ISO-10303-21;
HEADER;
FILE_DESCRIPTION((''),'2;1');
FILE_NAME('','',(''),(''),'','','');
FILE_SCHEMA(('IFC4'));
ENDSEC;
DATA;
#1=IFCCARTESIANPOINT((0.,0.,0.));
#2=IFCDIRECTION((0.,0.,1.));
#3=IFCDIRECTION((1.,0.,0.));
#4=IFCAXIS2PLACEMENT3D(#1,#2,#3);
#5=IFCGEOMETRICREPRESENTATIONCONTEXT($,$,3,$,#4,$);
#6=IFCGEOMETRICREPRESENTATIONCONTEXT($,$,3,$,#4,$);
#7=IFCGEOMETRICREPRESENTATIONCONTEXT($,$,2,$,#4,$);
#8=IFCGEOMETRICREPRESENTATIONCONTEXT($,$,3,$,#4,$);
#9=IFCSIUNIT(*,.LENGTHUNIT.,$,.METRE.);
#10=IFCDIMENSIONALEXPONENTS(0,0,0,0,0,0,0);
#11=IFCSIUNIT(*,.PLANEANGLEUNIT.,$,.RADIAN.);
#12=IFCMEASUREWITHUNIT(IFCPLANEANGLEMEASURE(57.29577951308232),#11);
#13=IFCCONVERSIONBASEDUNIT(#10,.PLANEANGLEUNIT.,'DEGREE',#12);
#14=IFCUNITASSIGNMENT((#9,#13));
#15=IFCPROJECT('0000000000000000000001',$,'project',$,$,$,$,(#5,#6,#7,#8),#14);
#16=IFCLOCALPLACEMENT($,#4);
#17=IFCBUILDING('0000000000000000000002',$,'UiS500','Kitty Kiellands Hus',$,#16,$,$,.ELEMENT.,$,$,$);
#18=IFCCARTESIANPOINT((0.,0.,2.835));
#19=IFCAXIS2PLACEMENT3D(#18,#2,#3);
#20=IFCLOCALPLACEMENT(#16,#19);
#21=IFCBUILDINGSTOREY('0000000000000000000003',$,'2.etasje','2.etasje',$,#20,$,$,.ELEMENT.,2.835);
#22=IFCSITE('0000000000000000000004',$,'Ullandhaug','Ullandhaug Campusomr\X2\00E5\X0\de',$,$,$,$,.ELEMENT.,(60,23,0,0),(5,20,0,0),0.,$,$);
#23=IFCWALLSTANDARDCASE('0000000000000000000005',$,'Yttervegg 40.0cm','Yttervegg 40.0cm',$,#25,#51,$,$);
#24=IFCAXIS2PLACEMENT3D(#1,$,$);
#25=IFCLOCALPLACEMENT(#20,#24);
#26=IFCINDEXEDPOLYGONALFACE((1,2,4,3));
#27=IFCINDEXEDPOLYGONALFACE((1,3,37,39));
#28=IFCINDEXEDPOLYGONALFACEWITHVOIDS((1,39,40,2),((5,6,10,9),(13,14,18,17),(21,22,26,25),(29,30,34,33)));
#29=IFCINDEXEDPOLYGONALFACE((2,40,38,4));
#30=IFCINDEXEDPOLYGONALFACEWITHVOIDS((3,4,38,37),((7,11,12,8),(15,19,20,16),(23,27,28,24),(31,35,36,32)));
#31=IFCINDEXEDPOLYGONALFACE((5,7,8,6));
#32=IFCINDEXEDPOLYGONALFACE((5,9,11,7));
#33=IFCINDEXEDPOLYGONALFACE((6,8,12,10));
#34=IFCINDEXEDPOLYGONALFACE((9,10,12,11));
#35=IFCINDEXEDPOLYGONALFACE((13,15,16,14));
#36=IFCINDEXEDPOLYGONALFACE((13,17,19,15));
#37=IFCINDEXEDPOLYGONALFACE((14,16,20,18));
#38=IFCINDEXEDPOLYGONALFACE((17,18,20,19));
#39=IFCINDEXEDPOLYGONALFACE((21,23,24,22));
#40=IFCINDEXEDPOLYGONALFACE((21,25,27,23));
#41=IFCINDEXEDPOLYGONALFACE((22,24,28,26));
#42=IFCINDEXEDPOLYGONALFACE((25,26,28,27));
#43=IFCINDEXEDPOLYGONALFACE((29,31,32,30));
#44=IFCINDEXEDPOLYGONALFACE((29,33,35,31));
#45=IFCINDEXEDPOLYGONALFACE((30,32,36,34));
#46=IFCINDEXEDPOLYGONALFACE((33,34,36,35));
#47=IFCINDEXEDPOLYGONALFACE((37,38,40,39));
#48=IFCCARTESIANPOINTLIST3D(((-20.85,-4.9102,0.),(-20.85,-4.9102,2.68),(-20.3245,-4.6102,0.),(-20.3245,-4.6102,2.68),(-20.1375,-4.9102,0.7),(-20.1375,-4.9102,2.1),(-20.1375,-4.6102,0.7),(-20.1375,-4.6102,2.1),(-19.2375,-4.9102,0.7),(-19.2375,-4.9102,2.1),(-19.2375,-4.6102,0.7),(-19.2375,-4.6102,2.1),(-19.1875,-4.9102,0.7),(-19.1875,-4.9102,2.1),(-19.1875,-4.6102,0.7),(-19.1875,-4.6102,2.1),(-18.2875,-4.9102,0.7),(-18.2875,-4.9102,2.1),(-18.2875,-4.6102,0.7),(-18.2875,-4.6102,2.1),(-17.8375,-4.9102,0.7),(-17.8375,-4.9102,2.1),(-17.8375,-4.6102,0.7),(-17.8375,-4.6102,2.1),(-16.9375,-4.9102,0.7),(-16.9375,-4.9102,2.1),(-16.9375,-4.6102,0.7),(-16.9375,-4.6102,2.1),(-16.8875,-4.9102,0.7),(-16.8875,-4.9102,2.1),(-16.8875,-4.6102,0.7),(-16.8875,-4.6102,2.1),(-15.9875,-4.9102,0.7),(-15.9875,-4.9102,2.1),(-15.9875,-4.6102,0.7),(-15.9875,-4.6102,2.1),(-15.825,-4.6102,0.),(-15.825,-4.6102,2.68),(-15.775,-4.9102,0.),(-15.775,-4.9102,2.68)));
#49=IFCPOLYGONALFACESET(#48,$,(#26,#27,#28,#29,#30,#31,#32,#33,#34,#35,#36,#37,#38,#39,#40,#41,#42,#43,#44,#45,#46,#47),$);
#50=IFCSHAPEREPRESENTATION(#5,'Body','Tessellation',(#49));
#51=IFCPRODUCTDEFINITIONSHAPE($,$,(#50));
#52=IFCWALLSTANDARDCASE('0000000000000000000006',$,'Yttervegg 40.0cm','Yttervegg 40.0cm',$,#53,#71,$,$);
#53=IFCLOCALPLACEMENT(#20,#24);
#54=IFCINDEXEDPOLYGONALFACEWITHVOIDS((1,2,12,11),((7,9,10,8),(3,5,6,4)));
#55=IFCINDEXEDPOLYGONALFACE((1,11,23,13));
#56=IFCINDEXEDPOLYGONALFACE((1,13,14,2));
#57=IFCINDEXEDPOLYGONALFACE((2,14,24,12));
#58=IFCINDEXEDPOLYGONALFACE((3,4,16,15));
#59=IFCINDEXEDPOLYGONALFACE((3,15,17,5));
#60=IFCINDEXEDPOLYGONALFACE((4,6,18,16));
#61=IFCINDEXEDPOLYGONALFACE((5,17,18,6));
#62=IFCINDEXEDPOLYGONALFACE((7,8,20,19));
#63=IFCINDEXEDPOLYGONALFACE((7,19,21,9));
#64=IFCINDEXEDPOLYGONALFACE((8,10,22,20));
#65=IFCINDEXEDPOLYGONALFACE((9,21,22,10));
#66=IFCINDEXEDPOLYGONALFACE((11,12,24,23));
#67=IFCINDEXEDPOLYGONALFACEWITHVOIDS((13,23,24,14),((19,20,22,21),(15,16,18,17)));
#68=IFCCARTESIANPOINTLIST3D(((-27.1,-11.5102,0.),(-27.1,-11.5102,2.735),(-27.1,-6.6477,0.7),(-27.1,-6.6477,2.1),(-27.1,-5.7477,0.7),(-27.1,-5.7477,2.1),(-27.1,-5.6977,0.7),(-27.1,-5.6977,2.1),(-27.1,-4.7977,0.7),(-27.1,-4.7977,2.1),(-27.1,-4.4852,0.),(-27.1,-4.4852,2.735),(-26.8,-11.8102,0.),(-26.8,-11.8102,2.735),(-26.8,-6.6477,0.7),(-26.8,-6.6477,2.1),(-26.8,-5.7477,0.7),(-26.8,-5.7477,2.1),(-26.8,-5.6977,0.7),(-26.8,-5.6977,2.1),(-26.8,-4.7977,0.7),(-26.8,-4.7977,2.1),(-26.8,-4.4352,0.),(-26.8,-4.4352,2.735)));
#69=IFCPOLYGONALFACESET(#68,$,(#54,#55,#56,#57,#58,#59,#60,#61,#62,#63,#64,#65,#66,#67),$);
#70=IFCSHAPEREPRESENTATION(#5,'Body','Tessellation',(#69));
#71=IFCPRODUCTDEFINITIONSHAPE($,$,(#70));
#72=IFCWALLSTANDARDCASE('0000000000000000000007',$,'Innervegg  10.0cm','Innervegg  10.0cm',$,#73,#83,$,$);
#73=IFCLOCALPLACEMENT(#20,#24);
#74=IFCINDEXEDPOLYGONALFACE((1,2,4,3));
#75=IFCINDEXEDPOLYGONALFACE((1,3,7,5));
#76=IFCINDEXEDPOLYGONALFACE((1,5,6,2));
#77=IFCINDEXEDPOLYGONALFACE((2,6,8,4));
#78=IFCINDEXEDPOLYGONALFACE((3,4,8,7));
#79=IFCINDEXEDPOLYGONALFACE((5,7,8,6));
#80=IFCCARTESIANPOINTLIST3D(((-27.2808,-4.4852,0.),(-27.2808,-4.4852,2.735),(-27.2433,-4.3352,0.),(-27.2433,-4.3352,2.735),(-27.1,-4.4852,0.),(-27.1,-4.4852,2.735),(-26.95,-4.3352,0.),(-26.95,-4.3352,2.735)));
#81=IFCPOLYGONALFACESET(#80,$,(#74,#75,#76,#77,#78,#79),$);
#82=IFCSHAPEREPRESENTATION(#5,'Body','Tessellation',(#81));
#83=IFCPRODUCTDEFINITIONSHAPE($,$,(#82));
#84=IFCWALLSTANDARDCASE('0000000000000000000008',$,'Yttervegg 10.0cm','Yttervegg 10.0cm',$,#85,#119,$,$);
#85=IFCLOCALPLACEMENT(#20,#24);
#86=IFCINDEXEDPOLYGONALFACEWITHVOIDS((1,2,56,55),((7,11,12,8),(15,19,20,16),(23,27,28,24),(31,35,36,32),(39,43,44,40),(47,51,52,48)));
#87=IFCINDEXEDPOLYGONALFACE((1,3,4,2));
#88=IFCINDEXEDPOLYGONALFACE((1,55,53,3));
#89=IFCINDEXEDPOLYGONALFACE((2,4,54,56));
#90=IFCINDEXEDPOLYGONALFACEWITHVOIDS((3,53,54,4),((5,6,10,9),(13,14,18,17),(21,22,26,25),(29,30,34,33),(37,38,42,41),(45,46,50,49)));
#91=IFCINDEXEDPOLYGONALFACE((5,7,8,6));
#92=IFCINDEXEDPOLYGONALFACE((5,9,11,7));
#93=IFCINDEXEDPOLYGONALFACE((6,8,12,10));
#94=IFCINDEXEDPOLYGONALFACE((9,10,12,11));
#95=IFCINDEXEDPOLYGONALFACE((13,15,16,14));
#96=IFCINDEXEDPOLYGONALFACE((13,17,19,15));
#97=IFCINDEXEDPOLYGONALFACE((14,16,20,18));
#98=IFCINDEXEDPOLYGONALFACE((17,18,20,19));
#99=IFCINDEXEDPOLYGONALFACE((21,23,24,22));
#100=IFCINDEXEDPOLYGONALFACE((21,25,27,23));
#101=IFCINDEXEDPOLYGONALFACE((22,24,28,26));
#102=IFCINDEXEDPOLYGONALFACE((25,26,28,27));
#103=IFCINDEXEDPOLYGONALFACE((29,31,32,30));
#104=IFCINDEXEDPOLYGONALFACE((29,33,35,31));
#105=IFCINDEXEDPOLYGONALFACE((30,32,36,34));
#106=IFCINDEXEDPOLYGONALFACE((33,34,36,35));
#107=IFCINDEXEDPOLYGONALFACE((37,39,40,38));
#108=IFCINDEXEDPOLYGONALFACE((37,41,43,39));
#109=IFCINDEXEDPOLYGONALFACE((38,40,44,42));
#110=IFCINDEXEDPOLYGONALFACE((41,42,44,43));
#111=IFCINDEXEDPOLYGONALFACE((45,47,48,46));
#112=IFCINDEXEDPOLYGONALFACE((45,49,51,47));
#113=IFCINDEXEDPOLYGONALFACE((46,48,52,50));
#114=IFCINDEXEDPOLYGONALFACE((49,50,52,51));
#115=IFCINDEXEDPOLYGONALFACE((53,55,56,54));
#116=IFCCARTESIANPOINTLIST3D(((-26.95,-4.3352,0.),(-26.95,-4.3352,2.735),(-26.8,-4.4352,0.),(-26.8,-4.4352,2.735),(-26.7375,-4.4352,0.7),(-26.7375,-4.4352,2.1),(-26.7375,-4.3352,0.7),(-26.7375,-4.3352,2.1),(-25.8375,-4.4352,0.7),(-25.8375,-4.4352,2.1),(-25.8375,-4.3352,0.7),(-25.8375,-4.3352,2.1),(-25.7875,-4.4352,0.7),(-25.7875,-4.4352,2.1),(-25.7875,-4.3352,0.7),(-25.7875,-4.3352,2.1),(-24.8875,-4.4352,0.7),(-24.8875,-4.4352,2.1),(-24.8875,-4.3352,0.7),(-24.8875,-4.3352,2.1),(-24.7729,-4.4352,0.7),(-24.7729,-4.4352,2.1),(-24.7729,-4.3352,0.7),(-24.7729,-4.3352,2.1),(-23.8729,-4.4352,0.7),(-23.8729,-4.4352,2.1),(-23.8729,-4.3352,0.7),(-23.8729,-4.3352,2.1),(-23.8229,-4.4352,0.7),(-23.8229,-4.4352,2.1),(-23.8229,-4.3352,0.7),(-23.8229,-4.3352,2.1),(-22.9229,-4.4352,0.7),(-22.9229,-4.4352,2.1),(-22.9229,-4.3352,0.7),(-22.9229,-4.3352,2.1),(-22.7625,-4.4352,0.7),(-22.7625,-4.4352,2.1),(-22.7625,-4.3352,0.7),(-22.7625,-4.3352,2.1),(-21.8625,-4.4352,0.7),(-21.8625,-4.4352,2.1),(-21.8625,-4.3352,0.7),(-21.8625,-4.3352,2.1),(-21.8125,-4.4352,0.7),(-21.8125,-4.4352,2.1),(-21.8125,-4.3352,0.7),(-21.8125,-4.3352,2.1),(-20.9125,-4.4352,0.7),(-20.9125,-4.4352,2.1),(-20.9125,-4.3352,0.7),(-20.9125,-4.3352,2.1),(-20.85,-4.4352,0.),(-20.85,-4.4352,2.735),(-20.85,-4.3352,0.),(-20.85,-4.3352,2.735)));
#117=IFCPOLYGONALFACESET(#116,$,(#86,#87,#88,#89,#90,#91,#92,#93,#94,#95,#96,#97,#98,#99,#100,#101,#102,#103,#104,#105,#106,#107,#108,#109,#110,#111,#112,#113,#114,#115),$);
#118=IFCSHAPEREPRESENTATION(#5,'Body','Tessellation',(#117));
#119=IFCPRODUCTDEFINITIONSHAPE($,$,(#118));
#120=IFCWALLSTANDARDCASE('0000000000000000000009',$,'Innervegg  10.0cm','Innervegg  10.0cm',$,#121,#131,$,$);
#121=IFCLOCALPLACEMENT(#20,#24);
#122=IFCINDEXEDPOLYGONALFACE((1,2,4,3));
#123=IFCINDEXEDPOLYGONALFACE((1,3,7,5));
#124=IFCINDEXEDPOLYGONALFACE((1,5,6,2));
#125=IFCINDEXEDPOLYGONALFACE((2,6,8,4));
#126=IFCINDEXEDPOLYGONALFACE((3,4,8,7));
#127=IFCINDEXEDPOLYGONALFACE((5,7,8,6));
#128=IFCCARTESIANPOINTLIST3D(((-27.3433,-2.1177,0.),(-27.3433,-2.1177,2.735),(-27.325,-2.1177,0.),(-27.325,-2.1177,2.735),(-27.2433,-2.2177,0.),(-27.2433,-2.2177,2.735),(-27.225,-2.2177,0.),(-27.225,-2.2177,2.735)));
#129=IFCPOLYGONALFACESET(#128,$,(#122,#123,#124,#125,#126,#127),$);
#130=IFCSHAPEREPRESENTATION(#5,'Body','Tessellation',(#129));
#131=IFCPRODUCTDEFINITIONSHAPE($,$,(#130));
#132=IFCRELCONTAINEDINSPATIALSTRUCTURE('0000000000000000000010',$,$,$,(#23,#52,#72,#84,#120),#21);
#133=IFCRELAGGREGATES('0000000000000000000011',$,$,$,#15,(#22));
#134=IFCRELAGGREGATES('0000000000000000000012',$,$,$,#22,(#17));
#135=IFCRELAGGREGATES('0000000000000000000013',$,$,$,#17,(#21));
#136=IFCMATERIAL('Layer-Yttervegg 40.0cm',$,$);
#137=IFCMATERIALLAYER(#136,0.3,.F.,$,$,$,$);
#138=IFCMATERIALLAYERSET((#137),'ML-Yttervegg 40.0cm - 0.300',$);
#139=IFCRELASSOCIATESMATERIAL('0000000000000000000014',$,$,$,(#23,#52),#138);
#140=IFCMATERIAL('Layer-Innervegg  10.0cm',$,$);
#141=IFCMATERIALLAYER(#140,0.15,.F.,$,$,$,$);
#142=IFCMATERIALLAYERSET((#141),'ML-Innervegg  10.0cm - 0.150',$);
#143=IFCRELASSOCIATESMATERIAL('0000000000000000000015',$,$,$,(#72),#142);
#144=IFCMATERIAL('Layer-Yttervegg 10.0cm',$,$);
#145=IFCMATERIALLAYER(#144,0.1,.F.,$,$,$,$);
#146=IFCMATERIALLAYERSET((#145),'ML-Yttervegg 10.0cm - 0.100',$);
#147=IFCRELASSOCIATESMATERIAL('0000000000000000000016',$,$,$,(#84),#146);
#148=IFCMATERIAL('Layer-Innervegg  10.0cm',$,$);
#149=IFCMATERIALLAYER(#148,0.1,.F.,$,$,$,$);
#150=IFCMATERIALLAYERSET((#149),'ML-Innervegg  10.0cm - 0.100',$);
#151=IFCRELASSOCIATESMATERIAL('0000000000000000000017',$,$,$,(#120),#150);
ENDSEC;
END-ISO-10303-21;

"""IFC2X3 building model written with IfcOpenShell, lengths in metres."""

from ifc_helpers import new_model, entity, si_unit, converted_unit, frame, origin_with_axes, place, context, project, spatial, polyline, outline, extrude, material, layer, layer_set, layer_usage, element, save


model = new_model("IFC2X3")

# Units and contexts
context_of_model_1 = context(None, 3, world=origin_with_axes())
context_of_model_2 = context(None, 3, world=origin_with_axes())
context_of_model_3 = context(None, 2, world=origin_with_axes())
context_of_model_4 = context(None, 3, world=origin_with_axes())
ifc_project = project(units=[si_unit("LENGTHUNIT", "METRE"), converted_unit("PLANEANGLEUNIT", "DEGREE", entity("IfcPlaneAngleMeasure", 57.29577951308232), si_unit("PLANEANGLEUNIT", "RADIAN"), dimensions=[0, 0, 0, 0, 0, 0, 0])], contexts=[context_of_model_1, context_of_model_2, context_of_model_3, context_of_model_4])

# Site, building, storey
site = spatial("IfcSite", under=ifc_project, Name="Ullandhaug", Description="Ullandhaug Campusområde", CompositionType="ELEMENT", RefLatitude=(60, 23, 0, 0), RefLongitude=(5, 20, 0, 0), RefElevation=0.0)
building_placement = place(None, origin_with_axes())
building = spatial("IfcBuilding", under=site, at=building_placement, Name="UiS500", Description="Kitty Kiellands Hus", CompositionType="ELEMENT")
storey_placement = place(building_placement, frame((0.0, 0.0, 2.835), z_axis=(0.0, 0.0, 1.0), x_axis=(1.0, 0.0, 0.0)))
storey = spatial("IfcBuildingStorey", under=building, at=storey_placement, Name="2.etasje", Description="2.etasje", CompositionType="ELEMENT", Elevation=2.835)

# Shared definitions
ifc_material_1 = material(Name="Layer-Innervegg  10.0cm")
ifc_layer_1 = layer(ifc_material_1, 0.1, ventilated=False)
ifc_layer_set_1 = layer_set([ifc_layer_1], Name="ML-Innervegg  10.0cm - 0.100")
ifc_layer_usage_1 = layer_usage(ifc_layer_set_1, "AXIS2", "POSITIVE", 0.0)

# Walls, openings
ifc_material_2 = material(Name="Layer-Yttervegg 40.0cm")
ifc_layer_2 = layer(ifc_material_2, 0.3, ventilated=False)
ifc_layer_set_2 = layer_set([ifc_layer_2], Name="ML-Yttervegg 40.0cm - 0.300")
ifc_layer_usage_2 = layer_usage(ifc_layer_set_2, "AXIS2", "POSITIVE", 0.0)
wall_1_placement = place(storey_placement, frame((-20.85, -4.9102, 0.0), z_axis=(0.0, 0.0, 1.0), x_axis=(1.0, 0.0, 0.0)))
wall_1 = element("IfcWallStandardCase", 1, at=wall_1_placement, inside=storey, material=ifc_layer_usage_2, Name="Yttervegg 40.0cm", Description="Yttervegg 40.0cm", context=context_of_model_1, shape_type="SweptSolid", body=[
    extrude(outline(polyline([(0.0, 0.0), (5.075, 0.0), (5.025, 0.3), (0.5255, 0.3), (0.0, 0.0)])), origin_with_axes(), (0.0, 0.0, 1.0), 2.68),
])
opening_1_placement = place(wall_1_placement, frame((0.7125, 0.3, 0.7), z_axis=(0.0, 0.0, 1.0), x_axis=(1.0, 0.0, 0.0)))
element("IfcOpeningElement", 2, at=opening_1_placement, cuts=wall_1, context=context_of_model_1, shape_type="SweptSolid", body=[
    extrude(outline(polyline([(0.0, 0.0), (1.4, 0.0), (1.4, 0.9), (0.0, 0.9), (0.0, 0.0)])), frame((0.0, 0.0, 0.0), z_axis=(0.0, 1.0, 0.0), x_axis=(0.0, 0.0, 1.0)), (0.0, 0.0, -1.0), 0.3),
])
opening_2_placement = place(wall_1_placement, frame((1.6625, 0.3, 0.7), z_axis=(0.0, 0.0, 1.0), x_axis=(1.0, 0.0, 0.0)))
element("IfcOpeningElement", 3, at=opening_2_placement, cuts=wall_1, context=context_of_model_1, shape_type="SweptSolid", body=[
    extrude(outline(polyline([(0.0, 0.0), (1.4, 0.0), (1.4, 0.9), (0.0, 0.9), (0.0, 0.0)])), frame((0.0, 0.0, 0.0), z_axis=(0.0, 1.0, 0.0), x_axis=(0.0, 0.0, 1.0)), (0.0, 0.0, -1.0), 0.3),
])
opening_3_placement = place(wall_1_placement, frame((3.0125, 0.3, 0.7), z_axis=(0.0, 0.0, 1.0), x_axis=(1.0, 0.0, 0.0)))
element("IfcOpeningElement", 4, at=opening_3_placement, cuts=wall_1, context=context_of_model_1, shape_type="SweptSolid", body=[
    extrude(outline(polyline([(0.0, 0.0), (1.4, 0.0), (1.4, 0.9), (0.0, 0.9), (0.0, 0.0)])), frame((0.0, 0.0, 0.0), z_axis=(0.0, 1.0, 0.0), x_axis=(0.0, 0.0, 1.0)), (0.0, 0.0, -1.0), 0.3),
])
opening_4_placement = place(wall_1_placement, frame((3.9625, 0.3, 0.7), z_axis=(0.0, 0.0, 1.0), x_axis=(1.0, 0.0, 0.0)))
element("IfcOpeningElement", 5, at=opening_4_placement, cuts=wall_1, context=context_of_model_1, shape_type="SweptSolid", body=[
    extrude(outline(polyline([(0.0, 0.0), (1.4, 0.0), (1.4, 0.9), (0.0, 0.9), (0.0, 0.0)])), frame((0.0, 0.0, 0.0), z_axis=(0.0, 1.0, 0.0), x_axis=(0.0, 0.0, 1.0)), (0.0, 0.0, -1.0), 0.3),
])
wall_2_placement = place(storey_placement, frame((-26.8, -11.8102, 0.0), z_axis=(0.0, 0.0, 1.0), x_axis=(0.0, 1.0, 0.0)))
wall_2 = element("IfcWallStandardCase", 6, at=wall_2_placement, inside=storey, material=ifc_layer_usage_2, Name="Yttervegg 40.0cm", Description="Yttervegg 40.0cm", context=context_of_model_1, shape_type="SweptSolid", body=[
    extrude(outline(polyline([(0.0, 0.0), (7.375, 0.0), (7.325, 0.3), (0.3, 0.3), (0.0, 0.0)])), frame((0.0, 0.0, 0.0), z_axis=(0.0, 0.0, 1.0), x_axis=(1.0, 0.0, 0.0)), (0.0, 0.0, 1.0), 2.735),
])
opening_5_placement = place(wall_2_placement, frame((5.1625, 0.3, 0.7), z_axis=(0.0, 0.0, 1.0), x_axis=(1.0, 0.0, 0.0)))
element("IfcOpeningElement", 7, at=opening_5_placement, cuts=wall_2, context=context_of_model_1, shape_type="SweptSolid", body=[
    extrude(outline(polyline([(0.0, 0.0), (1.4, 0.0), (1.4, 0.9), (0.0, 0.9), (0.0, 0.0)])), frame((0.0, 0.0, 0.0), z_axis=(0.0, 1.0, 0.0), x_axis=(0.0, 0.0, 1.0)), (0.0, 0.0, -1.0), 0.3),
])
opening_6_placement = place(wall_2_placement, frame((6.1125, 0.3, 0.7), z_axis=(0.0, 0.0, 1.0), x_axis=(1.0, 0.0, 0.0)))
element("IfcOpeningElement", 8, at=opening_6_placement, cuts=wall_2, context=context_of_model_1, shape_type="SweptSolid", body=[
    extrude(outline(polyline([(0.0, 0.0), (1.4, 0.0), (1.4, 0.9), (0.0, 0.9), (0.0, 0.0)])), frame((0.0, 0.0, 0.0), z_axis=(0.0, 1.0, 0.0), x_axis=(0.0, 0.0, 1.0)), (0.0, 0.0, -1.0), 0.3),
])

# Wall
ifc_material_3 = material(Name="Layer-Innervegg  10.0cm")
ifc_layer_3 = layer(ifc_material_3, 0.15, ventilated=False)
ifc_layer_set_3 = layer_set([ifc_layer_3], Name="ML-Innervegg  10.0cm - 0.150")
ifc_layer_usage_3 = layer_usage(ifc_layer_set_3, "AXIS2", "POSITIVE", 0.0)
wall_3_placement = place(storey_placement, frame((-26.95, -4.3352, 0.0), z_axis=(0.0, 0.0, 1.0), x_axis=(-1.0, 0.0, 0.0)))
element("IfcWallStandardCase", 9, at=wall_3_placement, inside=storey, material=ifc_layer_usage_3, Name="Innervegg  10.0cm", Description="Innervegg  10.0cm", context=context_of_model_1, shape_type="SweptSolid", body=[
    extrude(outline(polyline([(0.0, 0.0), (0.2933, 0.0), (0.3308, 0.15), (0.15, 0.15), (0.0, 0.0)])), frame((0.0, 0.0, 0.0), z_axis=(0.0, 0.0, 1.0), x_axis=(1.0, 0.0, 0.0)), (0.0, 0.0, 1.0), 2.735),
])

# Wall, openings
ifc_material_4 = material(Name="Layer-Yttervegg 10.0cm")
ifc_layer_4 = layer(ifc_material_4, 0.1, ventilated=False)
ifc_layer_set_4 = layer_set([ifc_layer_4], Name="ML-Yttervegg 10.0cm - 0.100")
ifc_layer_usage_4 = layer_usage(ifc_layer_set_4, "AXIS2", "POSITIVE", 0.0)
wall_4_placement = place(storey_placement, frame((-26.8, -4.4352, 0.0), z_axis=(0.0, 0.0, 1.0), x_axis=(1.0, 0.0, 0.0)))
wall_4 = element("IfcWallStandardCase", 10, at=wall_4_placement, inside=storey, material=ifc_layer_usage_4, Name="Yttervegg 10.0cm", Description="Yttervegg 10.0cm", context=context_of_model_1, shape_type="SweptSolid", body=[
    extrude(outline(polyline([(0.0, 0.0), (5.95, 0.0), (5.95, 0.1), (-0.15, 0.1), (0.0, 0.0)])), origin_with_axes(), (0.0, 0.0, 1.0), 2.735),
])
opening_7_placement = place(wall_4_placement, frame((0.0625, 0.1, 0.7), z_axis=(0.0, 0.0, 1.0), x_axis=(1.0, 0.0, 0.0)))
element("IfcOpeningElement", 11, at=opening_7_placement, cuts=wall_4, context=context_of_model_1, shape_type="SweptSolid", body=[
    extrude(outline(polyline([(0.0, 0.0), (1.4, 0.0), (1.4, 0.9), (0.0, 0.9), (0.0, 0.0)])), frame((0.0, 0.0, 0.0), z_axis=(0.0, 1.0, 0.0), x_axis=(0.0, 0.0, 1.0)), (0.0, 0.0, -1.0), 0.1),
])
opening_8_placement = place(wall_4_placement, frame((1.0125, 0.1, 0.7), z_axis=(0.0, 0.0, 1.0), x_axis=(1.0, 0.0, 0.0)))
element("IfcOpeningElement", 12, at=opening_8_placement, cuts=wall_4, context=context_of_model_1, shape_type="SweptSolid", body=[
    extrude(outline(polyline([(0.0, 0.0), (1.4, 0.0), (1.4, 0.9), (0.0, 0.9), (0.0, 0.0)])), frame((0.0, 0.0, 0.0), z_axis=(0.0, 1.0, 0.0), x_axis=(0.0, 0.0, 1.0)), (0.0, 0.0, -1.0), 0.1),
])
opening_9_placement = place(wall_4_placement, frame((2.0271, 0.1, 0.7), z_axis=(0.0, 0.0, 1.0), x_axis=(1.0, 0.0, 0.0)))
element("IfcOpeningElement", 13, at=opening_9_placement, cuts=wall_4, context=context_of_model_1, shape_type="SweptSolid", body=[
    extrude(outline(polyline([(0.0, 0.0), (1.4, 0.0), (1.4, 0.9), (0.0, 0.9), (0.0, 0.0)])), frame((0.0, 0.0, 0.0), z_axis=(0.0, 1.0, 0.0), x_axis=(0.0, 0.0, 1.0)), (0.0, 0.0, -1.0), 0.1),
])
opening_10_placement = place(wall_4_placement, frame((2.9771, 0.1, 0.7), z_axis=(0.0, 0.0, 1.0), x_axis=(1.0, 0.0, 0.0)))
element("IfcOpeningElement", 14, at=opening_10_placement, cuts=wall_4, context=context_of_model_1, shape_type="SweptSolid", body=[
    extrude(outline(polyline([(0.0, 0.0), (1.4, 0.0), (1.4, 0.9), (0.0, 0.9), (0.0, 0.0)])), frame((0.0, 0.0, 0.0), z_axis=(0.0, 1.0, 0.0), x_axis=(0.0, 0.0, 1.0)), (0.0, 0.0, -1.0), 0.1),
])
opening_11_placement = place(wall_4_placement, frame((4.0375, 0.1, 0.7), z_axis=(0.0, 0.0, 1.0), x_axis=(1.0, 0.0, 0.0)))
element("IfcOpeningElement", 15, at=opening_11_placement, cuts=wall_4, context=context_of_model_1, shape_type="SweptSolid", body=[
    extrude(outline(polyline([(0.0, 0.0), (1.4, 0.0), (1.4, 0.9), (0.0, 0.9), (0.0, 0.0)])), frame((0.0, 0.0, 0.0), z_axis=(0.0, 1.0, 0.0), x_axis=(0.0, 0.0, 1.0)), (0.0, 0.0, -1.0), 0.1),
])
opening_12_placement = place(wall_4_placement, frame((4.9875, 0.1, 0.7), z_axis=(0.0, 0.0, 1.0), x_axis=(1.0, 0.0, 0.0)))
element("IfcOpeningElement", 16, at=opening_12_placement, cuts=wall_4, context=context_of_model_1, shape_type="SweptSolid", body=[
    extrude(outline(polyline([(0.0, 0.0), (1.4, 0.0), (1.4, 0.9), (0.0, 0.9), (0.0, 0.0)])), frame((0.0, 0.0, 0.0), z_axis=(0.0, 1.0, 0.0), x_axis=(0.0, 0.0, 1.0)), (0.0, 0.0, -1.0), 0.1),
])

# Wall
wall_5_placement = place(storey_placement, frame((-27.325, -2.1177, 0.0), z_axis=(0.0, 0.0, 1.0), x_axis=(-1.0, 0.0, 0.0)))
element("IfcWallStandardCase", 17, at=wall_5_placement, inside=storey, material=ifc_layer_usage_1, Name="Innervegg  10.0cm", Description="Innervegg  10.0cm", context=context_of_model_1, shape_type="SweptSolid", body=[
    extrude(outline(polyline([(0.0, 0.0), (0.0183, 0.0), (-0.0817, 0.1), (-0.1, 0.1), (0.0, 0.0)])), frame((0.0, 0.0, 0.0), z_axis=(0.0, 0.0, 1.0), x_axis=(1.0, 0.0, 0.0)), (0.0, 0.0, 1.0), 2.735),
])

save(model, "model.ifc")
